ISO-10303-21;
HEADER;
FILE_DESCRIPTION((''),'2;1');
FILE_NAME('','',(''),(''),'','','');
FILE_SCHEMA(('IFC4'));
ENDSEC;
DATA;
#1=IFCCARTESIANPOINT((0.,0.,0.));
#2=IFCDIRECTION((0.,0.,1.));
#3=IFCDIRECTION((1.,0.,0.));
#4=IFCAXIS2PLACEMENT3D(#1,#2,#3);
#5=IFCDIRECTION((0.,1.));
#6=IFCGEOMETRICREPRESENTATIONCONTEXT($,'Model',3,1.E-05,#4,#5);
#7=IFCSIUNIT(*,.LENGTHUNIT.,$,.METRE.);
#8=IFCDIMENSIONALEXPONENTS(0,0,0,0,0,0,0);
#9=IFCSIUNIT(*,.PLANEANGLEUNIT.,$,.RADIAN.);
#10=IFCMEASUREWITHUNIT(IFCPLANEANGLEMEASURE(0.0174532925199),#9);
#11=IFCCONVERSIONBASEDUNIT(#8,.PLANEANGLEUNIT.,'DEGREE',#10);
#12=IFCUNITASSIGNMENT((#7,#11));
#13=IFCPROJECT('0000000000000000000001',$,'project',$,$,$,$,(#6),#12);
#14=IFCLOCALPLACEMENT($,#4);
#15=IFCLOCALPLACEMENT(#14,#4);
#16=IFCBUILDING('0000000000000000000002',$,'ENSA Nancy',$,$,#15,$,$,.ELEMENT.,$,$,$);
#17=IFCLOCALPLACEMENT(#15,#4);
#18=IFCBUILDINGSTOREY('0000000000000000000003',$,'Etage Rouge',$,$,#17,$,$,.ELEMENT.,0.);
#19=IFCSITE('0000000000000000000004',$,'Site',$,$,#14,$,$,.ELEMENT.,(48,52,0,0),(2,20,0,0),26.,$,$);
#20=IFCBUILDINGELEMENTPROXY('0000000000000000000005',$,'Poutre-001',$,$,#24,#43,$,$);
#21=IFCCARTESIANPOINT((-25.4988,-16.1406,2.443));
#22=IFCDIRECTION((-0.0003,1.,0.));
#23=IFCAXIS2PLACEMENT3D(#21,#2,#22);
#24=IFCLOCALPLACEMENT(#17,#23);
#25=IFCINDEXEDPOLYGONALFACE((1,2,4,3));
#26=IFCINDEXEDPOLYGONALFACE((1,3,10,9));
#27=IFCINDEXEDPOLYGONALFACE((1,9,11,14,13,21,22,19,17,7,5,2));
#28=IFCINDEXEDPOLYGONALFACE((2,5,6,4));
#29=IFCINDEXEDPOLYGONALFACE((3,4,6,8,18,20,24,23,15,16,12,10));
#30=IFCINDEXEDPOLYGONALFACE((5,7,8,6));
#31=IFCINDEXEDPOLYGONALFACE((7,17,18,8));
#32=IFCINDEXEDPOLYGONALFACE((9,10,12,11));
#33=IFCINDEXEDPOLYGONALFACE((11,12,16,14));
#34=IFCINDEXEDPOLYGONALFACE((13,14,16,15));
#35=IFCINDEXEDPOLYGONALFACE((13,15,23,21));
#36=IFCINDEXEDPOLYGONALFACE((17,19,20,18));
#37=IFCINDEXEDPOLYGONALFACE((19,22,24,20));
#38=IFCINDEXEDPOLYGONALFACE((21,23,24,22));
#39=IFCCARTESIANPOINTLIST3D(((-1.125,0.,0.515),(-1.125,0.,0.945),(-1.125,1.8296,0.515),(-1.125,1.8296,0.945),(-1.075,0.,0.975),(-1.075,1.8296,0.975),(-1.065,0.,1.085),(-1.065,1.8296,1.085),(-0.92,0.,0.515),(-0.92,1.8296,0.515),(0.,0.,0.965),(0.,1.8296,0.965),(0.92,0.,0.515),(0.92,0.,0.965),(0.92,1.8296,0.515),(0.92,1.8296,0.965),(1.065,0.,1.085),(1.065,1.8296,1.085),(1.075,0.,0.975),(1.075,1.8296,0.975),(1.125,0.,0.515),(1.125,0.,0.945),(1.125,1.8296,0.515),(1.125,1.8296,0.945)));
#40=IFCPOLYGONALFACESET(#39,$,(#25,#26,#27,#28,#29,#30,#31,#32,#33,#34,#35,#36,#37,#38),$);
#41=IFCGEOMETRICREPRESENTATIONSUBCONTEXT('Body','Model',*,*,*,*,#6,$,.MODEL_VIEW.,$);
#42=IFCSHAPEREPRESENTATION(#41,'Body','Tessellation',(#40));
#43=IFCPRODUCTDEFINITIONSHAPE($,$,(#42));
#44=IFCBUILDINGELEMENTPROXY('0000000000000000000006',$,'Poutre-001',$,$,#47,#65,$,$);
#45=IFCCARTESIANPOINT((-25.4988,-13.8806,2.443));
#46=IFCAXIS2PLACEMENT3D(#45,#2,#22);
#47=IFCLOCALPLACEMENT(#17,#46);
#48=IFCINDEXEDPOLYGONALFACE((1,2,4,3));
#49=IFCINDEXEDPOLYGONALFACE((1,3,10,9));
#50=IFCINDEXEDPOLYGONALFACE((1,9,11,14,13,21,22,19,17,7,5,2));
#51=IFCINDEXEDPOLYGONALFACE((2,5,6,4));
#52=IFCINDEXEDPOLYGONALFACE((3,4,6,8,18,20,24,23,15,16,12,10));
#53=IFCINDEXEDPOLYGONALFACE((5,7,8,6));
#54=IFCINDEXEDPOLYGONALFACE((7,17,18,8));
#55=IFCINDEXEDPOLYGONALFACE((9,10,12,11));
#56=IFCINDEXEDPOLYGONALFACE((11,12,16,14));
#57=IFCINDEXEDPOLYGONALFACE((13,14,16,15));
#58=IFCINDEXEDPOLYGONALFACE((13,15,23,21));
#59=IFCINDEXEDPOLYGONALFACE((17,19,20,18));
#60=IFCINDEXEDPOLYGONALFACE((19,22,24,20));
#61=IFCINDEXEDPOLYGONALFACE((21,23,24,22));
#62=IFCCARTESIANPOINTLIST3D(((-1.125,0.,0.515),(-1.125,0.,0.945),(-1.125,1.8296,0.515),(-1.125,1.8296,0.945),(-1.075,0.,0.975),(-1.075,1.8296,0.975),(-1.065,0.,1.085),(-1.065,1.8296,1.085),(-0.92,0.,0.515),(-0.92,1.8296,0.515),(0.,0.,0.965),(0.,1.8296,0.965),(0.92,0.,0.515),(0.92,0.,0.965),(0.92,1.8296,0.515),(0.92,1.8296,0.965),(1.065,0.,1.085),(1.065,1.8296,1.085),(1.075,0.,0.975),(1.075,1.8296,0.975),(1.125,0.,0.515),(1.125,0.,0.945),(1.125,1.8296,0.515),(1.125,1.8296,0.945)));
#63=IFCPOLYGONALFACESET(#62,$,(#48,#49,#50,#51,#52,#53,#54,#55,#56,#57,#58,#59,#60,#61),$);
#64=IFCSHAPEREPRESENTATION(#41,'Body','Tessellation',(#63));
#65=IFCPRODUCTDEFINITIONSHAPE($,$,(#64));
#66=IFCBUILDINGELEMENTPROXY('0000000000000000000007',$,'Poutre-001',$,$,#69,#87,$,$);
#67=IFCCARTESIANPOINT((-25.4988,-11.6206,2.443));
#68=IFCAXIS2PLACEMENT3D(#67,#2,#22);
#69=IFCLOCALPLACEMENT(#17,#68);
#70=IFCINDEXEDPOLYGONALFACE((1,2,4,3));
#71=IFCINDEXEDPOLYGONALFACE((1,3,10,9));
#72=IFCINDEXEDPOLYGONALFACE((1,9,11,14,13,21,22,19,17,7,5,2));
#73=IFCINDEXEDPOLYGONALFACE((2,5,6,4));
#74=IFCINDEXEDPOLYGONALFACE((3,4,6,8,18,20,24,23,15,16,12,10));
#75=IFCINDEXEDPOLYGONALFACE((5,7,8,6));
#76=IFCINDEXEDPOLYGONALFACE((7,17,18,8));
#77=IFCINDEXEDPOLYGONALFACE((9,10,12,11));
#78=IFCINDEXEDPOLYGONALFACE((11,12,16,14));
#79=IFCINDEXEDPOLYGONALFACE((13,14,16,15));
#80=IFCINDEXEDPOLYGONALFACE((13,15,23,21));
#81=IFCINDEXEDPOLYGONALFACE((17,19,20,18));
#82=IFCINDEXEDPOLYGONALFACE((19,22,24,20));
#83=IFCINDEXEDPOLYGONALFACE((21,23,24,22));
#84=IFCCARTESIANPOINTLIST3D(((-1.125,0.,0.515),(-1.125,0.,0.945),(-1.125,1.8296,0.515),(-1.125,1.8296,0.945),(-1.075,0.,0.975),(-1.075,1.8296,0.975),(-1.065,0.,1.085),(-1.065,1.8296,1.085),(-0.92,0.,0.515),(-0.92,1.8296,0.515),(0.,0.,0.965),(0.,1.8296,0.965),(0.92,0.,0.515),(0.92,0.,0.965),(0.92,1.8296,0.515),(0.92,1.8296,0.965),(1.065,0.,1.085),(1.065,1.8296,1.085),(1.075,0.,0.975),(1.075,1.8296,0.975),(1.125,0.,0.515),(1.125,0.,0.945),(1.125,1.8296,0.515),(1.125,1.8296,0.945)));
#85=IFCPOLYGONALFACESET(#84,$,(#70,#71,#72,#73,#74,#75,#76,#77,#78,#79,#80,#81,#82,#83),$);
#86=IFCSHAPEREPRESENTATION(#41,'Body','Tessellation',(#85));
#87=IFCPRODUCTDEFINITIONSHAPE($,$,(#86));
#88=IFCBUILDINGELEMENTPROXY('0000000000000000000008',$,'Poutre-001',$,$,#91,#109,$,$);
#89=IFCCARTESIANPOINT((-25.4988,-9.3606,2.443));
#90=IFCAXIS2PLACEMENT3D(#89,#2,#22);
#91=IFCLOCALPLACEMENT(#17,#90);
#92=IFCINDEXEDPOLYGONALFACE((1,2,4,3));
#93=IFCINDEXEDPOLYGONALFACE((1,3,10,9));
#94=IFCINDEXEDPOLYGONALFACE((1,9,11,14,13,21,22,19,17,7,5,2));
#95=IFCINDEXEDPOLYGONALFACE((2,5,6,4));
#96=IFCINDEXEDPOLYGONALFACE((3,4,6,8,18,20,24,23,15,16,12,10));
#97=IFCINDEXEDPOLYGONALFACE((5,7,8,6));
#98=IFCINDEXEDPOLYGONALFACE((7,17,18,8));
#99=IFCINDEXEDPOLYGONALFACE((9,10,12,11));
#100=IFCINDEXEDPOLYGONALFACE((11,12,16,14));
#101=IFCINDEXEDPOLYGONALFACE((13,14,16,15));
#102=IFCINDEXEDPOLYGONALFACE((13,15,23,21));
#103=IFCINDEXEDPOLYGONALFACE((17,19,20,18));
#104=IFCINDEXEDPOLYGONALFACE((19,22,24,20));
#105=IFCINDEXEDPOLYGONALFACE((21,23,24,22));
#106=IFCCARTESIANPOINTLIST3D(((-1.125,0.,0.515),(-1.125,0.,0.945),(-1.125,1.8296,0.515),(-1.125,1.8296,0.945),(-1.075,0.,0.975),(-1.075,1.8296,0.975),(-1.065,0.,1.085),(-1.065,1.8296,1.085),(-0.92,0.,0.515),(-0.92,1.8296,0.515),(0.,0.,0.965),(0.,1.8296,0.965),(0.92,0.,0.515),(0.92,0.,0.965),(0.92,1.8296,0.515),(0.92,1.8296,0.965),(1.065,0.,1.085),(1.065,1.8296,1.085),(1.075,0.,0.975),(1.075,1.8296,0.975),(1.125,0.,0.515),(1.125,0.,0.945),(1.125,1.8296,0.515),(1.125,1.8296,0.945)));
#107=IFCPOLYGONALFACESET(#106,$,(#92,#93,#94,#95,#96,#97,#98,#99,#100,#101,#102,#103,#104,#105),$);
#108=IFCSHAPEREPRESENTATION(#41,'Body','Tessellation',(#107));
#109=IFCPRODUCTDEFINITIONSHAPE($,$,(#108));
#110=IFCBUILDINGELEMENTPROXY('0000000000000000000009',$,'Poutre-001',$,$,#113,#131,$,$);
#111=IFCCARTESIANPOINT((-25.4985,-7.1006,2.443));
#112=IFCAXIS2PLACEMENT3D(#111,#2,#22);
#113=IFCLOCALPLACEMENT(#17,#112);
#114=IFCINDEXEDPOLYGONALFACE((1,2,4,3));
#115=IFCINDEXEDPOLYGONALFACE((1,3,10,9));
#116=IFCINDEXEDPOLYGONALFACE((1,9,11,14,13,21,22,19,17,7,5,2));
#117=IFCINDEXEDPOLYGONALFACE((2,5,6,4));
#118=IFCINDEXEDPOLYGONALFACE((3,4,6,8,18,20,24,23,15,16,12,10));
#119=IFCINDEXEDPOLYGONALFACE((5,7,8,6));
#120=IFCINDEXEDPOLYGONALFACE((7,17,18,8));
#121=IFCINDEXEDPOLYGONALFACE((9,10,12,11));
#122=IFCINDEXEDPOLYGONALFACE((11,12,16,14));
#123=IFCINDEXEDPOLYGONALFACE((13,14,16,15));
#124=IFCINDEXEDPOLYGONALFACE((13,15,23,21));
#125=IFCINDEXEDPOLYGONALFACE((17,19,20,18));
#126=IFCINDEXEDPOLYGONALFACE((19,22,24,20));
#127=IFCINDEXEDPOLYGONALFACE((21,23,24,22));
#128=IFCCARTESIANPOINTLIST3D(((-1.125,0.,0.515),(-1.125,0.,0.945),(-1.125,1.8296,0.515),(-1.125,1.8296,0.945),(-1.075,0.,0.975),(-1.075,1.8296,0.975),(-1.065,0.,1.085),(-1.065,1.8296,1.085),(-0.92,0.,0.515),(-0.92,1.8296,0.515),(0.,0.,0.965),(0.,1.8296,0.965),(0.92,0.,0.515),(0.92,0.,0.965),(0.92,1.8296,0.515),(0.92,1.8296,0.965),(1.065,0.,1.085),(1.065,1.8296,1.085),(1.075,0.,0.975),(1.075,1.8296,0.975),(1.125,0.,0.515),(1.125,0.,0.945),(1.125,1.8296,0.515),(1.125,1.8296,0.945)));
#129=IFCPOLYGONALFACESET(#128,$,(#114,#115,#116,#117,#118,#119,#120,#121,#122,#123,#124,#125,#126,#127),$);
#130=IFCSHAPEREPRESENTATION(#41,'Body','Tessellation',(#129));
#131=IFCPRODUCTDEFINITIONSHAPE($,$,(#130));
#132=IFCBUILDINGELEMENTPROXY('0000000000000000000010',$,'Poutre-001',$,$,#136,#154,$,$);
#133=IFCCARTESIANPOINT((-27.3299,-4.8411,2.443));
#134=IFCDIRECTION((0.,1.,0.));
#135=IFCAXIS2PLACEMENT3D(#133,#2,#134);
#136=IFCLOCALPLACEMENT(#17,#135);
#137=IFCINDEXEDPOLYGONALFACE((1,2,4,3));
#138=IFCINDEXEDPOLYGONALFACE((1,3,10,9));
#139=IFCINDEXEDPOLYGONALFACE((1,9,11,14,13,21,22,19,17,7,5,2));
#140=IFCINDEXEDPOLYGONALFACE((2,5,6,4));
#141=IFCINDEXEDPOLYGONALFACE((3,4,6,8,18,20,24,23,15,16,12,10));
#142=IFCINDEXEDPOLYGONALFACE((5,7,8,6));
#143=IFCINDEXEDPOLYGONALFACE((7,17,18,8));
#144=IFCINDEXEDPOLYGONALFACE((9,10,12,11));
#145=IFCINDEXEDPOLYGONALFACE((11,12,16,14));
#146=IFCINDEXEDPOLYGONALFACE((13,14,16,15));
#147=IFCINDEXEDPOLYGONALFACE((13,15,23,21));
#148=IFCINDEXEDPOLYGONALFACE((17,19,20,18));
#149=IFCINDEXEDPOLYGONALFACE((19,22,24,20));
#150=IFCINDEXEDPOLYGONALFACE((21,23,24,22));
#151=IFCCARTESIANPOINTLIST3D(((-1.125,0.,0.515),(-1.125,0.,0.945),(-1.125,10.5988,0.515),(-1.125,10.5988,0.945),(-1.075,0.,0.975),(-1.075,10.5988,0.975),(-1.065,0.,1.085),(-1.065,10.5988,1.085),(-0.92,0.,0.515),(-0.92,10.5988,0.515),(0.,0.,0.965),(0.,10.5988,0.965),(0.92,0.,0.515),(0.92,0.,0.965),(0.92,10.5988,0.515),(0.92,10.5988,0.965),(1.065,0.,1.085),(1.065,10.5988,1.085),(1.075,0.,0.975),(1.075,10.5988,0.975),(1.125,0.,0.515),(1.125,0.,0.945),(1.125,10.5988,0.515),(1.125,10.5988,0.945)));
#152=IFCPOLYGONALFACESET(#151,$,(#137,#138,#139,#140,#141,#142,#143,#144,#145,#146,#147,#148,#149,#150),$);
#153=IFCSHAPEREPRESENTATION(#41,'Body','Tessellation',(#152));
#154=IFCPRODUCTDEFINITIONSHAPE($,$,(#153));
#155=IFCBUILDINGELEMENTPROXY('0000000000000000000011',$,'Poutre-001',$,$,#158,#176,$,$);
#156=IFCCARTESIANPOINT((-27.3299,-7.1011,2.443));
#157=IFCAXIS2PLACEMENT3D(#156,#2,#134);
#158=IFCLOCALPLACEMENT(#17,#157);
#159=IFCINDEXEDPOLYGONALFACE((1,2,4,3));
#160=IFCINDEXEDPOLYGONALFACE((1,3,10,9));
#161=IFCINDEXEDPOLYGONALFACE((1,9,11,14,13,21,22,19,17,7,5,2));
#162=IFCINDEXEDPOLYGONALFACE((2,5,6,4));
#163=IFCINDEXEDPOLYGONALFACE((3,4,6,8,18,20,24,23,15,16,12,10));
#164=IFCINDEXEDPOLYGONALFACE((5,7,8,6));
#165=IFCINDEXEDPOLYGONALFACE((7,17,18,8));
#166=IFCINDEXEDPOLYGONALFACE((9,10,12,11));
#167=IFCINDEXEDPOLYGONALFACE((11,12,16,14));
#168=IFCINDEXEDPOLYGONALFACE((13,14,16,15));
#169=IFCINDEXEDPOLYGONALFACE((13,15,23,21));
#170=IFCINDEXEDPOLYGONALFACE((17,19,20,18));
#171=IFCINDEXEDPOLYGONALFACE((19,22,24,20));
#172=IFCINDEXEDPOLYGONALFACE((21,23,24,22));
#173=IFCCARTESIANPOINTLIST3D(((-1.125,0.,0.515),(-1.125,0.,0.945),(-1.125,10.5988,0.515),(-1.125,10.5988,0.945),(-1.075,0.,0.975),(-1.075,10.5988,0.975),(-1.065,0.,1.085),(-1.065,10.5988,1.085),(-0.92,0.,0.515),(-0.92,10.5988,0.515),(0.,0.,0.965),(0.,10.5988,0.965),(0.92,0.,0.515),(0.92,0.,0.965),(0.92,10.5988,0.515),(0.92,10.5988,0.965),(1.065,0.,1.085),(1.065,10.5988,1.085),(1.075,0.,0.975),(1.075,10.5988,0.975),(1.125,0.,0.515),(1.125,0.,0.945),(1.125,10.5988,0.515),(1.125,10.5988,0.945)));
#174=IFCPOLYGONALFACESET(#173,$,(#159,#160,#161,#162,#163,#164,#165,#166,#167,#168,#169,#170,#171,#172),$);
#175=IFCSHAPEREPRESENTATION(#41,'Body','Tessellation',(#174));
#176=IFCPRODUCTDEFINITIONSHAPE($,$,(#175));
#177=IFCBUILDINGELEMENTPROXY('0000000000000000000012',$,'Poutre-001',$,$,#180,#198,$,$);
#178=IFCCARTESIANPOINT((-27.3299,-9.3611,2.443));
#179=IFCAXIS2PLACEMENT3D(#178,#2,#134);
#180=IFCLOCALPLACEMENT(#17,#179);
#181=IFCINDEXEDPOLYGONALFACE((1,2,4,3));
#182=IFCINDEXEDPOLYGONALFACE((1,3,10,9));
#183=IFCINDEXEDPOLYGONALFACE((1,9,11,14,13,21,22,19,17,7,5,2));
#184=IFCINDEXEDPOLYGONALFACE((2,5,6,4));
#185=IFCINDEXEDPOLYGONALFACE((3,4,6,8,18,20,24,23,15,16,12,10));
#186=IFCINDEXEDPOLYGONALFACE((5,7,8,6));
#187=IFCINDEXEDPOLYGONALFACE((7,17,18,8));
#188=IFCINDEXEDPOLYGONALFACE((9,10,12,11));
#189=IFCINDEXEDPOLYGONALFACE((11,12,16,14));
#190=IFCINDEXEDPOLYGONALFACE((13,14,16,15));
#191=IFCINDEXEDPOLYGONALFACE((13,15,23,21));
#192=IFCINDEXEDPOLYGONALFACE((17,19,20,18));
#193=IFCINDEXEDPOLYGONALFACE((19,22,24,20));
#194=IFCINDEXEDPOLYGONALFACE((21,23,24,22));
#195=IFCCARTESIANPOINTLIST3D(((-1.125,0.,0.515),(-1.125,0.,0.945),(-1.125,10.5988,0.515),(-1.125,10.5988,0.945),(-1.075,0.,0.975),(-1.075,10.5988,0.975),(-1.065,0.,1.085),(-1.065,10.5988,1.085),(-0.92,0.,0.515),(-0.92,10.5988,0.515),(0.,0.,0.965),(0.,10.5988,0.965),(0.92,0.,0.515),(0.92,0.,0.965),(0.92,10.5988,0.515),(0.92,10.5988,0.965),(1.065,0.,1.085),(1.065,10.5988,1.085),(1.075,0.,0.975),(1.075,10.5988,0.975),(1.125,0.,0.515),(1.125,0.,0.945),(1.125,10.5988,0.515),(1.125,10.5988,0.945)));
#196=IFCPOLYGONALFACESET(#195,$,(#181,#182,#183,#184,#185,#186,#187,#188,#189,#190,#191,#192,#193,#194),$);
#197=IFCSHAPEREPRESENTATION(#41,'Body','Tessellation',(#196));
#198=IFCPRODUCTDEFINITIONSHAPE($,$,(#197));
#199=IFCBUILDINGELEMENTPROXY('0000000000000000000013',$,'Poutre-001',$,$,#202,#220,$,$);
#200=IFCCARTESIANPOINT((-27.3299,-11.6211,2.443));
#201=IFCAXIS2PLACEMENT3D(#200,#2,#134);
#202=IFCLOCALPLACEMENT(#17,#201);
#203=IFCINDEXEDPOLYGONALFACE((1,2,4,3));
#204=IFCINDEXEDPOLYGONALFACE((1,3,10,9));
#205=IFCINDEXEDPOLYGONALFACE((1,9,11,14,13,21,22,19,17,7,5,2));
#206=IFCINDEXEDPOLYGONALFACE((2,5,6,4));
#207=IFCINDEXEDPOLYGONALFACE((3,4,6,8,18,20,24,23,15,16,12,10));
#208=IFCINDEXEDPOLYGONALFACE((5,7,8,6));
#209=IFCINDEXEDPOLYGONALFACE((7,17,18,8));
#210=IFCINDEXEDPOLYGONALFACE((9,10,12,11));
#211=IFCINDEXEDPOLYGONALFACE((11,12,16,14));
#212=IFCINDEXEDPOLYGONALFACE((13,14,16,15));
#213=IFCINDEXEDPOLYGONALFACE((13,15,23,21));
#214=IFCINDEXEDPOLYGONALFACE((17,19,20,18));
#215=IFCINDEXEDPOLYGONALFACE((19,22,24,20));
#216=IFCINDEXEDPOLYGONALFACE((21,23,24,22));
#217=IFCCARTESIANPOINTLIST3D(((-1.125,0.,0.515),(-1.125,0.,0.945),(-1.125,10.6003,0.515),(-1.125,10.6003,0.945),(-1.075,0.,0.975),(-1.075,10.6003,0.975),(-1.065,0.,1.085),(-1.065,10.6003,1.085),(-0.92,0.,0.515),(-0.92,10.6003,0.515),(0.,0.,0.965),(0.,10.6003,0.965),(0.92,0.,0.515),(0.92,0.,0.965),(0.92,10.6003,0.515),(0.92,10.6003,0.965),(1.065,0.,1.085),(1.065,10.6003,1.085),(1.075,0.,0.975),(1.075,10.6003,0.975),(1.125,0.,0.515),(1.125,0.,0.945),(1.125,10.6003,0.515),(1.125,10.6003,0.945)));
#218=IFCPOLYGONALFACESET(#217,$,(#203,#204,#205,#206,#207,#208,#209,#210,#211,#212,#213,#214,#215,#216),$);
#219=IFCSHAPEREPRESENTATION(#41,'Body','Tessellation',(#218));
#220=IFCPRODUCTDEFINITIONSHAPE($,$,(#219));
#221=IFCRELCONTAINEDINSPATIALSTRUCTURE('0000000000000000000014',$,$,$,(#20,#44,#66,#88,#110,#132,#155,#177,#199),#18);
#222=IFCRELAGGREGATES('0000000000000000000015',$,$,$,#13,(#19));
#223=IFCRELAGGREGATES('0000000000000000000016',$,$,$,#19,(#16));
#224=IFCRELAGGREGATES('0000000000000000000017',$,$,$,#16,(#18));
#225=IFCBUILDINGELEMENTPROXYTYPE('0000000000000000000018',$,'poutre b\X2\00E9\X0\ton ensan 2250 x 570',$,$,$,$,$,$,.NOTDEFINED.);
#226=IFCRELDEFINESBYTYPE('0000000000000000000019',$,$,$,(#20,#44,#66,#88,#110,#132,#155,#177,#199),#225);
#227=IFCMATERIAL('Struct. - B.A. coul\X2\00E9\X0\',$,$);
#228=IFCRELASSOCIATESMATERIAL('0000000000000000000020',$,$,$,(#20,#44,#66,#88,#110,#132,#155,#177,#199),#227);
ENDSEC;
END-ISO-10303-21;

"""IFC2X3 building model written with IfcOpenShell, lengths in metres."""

from ifc_helpers import new_model, entity, si_unit, converted_unit, direction, frame, origin_with_axes, place, context, subcontext, project, spatial, polyline, outline, extrude, material, type_object, element, save


model = new_model("IFC2X3")

# Units and contexts
model_context = context("Model", 3, precision=1e-05, world=origin_with_axes(), true_north=direction((0.0, 1.0)))
body_context = subcontext(model_context, "Body", "Model", "MODEL_VIEW")
ifc_project = project(units=[si_unit("LENGTHUNIT", "METRE"), converted_unit("PLANEANGLEUNIT", "DEGREE", entity("IfcPlaneAngleMeasure", 0.0174532925199), si_unit("PLANEANGLEUNIT", "RADIAN"), dimensions=[0, 0, 0, 0, 0, 0, 0])], contexts=[model_context])

# Site, building, storey
site_placement = place(None, origin_with_axes())
site = spatial("IfcSite", under=ifc_project, at=site_placement, Name="Site", CompositionType="ELEMENT", RefLatitude=(48, 52, 0, 0), RefLongitude=(2, 20, 0, 0), RefElevation=26.0)
building_placement = place(site_placement, origin_with_axes())
building = spatial("IfcBuilding", under=site, at=building_placement, Name="ENSA Nancy", CompositionType="ELEMENT")
storey_placement = place(building_placement, origin_with_axes())
storey = spatial("IfcBuildingStorey", under=building, at=storey_placement, Name="Etage Rouge", CompositionType="ELEMENT", Elevation=0.0)

# Building element proxies
ifc_material_1 = material(Name="Struct. - B.A. coulé")
building_element_proxy_type_1 = type_object("IfcBuildingElementProxyType", Name="poutre béton ensan 2250 x 570", PredefinedType="NOTDEFINED")
for number, where, z_axis, x_axis, name in (
    (1, (-25.4988, -16.1406, 2.443), (0.0, 0.0, 1.0), (-0.0003, 1.0, 0.0), "Poutre-001"),
    (2, (-25.4988, -13.8806, 2.443), (0.0, 0.0, 1.0), (-0.0003, 1.0, 0.0), "Poutre-001"),
    (3, (-25.4988, -11.6206, 2.443), (0.0, 0.0, 1.0), (-0.0003, 1.0, 0.0), "Poutre-001"),
    (4, (-25.4988, -9.3606, 2.443), (0.0, 0.0, 1.0), (-0.0003, 1.0, 0.0), "Poutre-001"),
    (5, (-25.4985, -7.1006, 2.443), (0.0, 0.0, 1.0), (-0.0003, 1.0, 0.0), "Poutre-001"),
):
    element("IfcBuildingElementProxy", number, at=place(storey_placement, frame(where, z_axis=z_axis, x_axis=x_axis)), inside=storey, type_object=building_element_proxy_type_1, material=ifc_material_1, Name=name, context=body_context, shape_type="SweptSolid", body=[
        extrude(outline(polyline([(-1.065, 1.085), (-1.075, 0.975), (-1.125, 0.945), (-1.125, 0.515), (-0.92, 0.515), (0.0, 0.965), (0.92, 0.965), (0.92, 0.515), (1.125, 0.515), (1.125, 0.945), (1.075, 0.975), (1.065, 1.085), (-1.065, 1.085)])), frame((0.0, 1.8296, 0.0), z_axis=(0.0, -1.0, 0.0), x_axis=(1.0, 0.0, 0.0)), (0.0, 0.0, 1.0), 1.8296),
    ])
for number, where, z_axis, x_axis, name in (
    (6, (-27.3299, -4.8411, 2.443), (0.0, 0.0, 1.0), (0.0, 1.0, 0.0), "Poutre-001"),
    (7, (-27.3299, -7.1011, 2.443), (0.0, 0.0, 1.0), (0.0, 1.0, 0.0), "Poutre-001"),
    (8, (-27.3299, -9.3611, 2.443), (0.0, 0.0, 1.0), (0.0, 1.0, 0.0), "Poutre-001"),
):
    element("IfcBuildingElementProxy", number, at=place(storey_placement, frame(where, z_axis=z_axis, x_axis=x_axis)), inside=storey, type_object=building_element_proxy_type_1, material=ifc_material_1, Name=name, context=body_context, shape_type="SweptSolid", body=[
        extrude(outline(polyline([(-1.065, 1.085), (-1.075, 0.975), (-1.125, 0.945), (-1.125, 0.515), (-0.92, 0.515), (0.0, 0.965), (0.92, 0.965), (0.92, 0.515), (1.125, 0.515), (1.125, 0.945), (1.075, 0.975), (1.065, 1.085), (-1.065, 1.085)])), frame((0.0, 10.5988, 0.0), z_axis=(0.0, -1.0, 0.0), x_axis=(1.0, 0.0, 0.0)), (0.0, 0.0, 1.0), 10.5988),
    ])
proxy_1_placement = place(storey_placement, frame((-27.3299, -11.6211, 2.443), z_axis=(0.0, 0.0, 1.0), x_axis=(0.0, 1.0, 0.0)))
element("IfcBuildingElementProxy", 9, at=proxy_1_placement, inside=storey, type_object=building_element_proxy_type_1, material=ifc_material_1, Name="Poutre-001", context=body_context, shape_type="SweptSolid", body=[
    extrude(outline(polyline([(-1.065, 1.085), (-1.075, 0.975), (-1.125, 0.945), (-1.125, 0.515), (-0.92, 0.515), (0.0, 0.965), (0.92, 0.965), (0.92, 0.515), (1.125, 0.515), (1.125, 0.945), (1.075, 0.975), (1.065, 1.085), (-1.065, 1.085)])), frame((0.0, 10.6003, 0.0), z_axis=(0.0, -1.0, 0.0), x_axis=(1.0, 0.0, 0.0)), (0.0, 0.0, 1.0), 10.6003),
])

save(model, "model.ifc")
